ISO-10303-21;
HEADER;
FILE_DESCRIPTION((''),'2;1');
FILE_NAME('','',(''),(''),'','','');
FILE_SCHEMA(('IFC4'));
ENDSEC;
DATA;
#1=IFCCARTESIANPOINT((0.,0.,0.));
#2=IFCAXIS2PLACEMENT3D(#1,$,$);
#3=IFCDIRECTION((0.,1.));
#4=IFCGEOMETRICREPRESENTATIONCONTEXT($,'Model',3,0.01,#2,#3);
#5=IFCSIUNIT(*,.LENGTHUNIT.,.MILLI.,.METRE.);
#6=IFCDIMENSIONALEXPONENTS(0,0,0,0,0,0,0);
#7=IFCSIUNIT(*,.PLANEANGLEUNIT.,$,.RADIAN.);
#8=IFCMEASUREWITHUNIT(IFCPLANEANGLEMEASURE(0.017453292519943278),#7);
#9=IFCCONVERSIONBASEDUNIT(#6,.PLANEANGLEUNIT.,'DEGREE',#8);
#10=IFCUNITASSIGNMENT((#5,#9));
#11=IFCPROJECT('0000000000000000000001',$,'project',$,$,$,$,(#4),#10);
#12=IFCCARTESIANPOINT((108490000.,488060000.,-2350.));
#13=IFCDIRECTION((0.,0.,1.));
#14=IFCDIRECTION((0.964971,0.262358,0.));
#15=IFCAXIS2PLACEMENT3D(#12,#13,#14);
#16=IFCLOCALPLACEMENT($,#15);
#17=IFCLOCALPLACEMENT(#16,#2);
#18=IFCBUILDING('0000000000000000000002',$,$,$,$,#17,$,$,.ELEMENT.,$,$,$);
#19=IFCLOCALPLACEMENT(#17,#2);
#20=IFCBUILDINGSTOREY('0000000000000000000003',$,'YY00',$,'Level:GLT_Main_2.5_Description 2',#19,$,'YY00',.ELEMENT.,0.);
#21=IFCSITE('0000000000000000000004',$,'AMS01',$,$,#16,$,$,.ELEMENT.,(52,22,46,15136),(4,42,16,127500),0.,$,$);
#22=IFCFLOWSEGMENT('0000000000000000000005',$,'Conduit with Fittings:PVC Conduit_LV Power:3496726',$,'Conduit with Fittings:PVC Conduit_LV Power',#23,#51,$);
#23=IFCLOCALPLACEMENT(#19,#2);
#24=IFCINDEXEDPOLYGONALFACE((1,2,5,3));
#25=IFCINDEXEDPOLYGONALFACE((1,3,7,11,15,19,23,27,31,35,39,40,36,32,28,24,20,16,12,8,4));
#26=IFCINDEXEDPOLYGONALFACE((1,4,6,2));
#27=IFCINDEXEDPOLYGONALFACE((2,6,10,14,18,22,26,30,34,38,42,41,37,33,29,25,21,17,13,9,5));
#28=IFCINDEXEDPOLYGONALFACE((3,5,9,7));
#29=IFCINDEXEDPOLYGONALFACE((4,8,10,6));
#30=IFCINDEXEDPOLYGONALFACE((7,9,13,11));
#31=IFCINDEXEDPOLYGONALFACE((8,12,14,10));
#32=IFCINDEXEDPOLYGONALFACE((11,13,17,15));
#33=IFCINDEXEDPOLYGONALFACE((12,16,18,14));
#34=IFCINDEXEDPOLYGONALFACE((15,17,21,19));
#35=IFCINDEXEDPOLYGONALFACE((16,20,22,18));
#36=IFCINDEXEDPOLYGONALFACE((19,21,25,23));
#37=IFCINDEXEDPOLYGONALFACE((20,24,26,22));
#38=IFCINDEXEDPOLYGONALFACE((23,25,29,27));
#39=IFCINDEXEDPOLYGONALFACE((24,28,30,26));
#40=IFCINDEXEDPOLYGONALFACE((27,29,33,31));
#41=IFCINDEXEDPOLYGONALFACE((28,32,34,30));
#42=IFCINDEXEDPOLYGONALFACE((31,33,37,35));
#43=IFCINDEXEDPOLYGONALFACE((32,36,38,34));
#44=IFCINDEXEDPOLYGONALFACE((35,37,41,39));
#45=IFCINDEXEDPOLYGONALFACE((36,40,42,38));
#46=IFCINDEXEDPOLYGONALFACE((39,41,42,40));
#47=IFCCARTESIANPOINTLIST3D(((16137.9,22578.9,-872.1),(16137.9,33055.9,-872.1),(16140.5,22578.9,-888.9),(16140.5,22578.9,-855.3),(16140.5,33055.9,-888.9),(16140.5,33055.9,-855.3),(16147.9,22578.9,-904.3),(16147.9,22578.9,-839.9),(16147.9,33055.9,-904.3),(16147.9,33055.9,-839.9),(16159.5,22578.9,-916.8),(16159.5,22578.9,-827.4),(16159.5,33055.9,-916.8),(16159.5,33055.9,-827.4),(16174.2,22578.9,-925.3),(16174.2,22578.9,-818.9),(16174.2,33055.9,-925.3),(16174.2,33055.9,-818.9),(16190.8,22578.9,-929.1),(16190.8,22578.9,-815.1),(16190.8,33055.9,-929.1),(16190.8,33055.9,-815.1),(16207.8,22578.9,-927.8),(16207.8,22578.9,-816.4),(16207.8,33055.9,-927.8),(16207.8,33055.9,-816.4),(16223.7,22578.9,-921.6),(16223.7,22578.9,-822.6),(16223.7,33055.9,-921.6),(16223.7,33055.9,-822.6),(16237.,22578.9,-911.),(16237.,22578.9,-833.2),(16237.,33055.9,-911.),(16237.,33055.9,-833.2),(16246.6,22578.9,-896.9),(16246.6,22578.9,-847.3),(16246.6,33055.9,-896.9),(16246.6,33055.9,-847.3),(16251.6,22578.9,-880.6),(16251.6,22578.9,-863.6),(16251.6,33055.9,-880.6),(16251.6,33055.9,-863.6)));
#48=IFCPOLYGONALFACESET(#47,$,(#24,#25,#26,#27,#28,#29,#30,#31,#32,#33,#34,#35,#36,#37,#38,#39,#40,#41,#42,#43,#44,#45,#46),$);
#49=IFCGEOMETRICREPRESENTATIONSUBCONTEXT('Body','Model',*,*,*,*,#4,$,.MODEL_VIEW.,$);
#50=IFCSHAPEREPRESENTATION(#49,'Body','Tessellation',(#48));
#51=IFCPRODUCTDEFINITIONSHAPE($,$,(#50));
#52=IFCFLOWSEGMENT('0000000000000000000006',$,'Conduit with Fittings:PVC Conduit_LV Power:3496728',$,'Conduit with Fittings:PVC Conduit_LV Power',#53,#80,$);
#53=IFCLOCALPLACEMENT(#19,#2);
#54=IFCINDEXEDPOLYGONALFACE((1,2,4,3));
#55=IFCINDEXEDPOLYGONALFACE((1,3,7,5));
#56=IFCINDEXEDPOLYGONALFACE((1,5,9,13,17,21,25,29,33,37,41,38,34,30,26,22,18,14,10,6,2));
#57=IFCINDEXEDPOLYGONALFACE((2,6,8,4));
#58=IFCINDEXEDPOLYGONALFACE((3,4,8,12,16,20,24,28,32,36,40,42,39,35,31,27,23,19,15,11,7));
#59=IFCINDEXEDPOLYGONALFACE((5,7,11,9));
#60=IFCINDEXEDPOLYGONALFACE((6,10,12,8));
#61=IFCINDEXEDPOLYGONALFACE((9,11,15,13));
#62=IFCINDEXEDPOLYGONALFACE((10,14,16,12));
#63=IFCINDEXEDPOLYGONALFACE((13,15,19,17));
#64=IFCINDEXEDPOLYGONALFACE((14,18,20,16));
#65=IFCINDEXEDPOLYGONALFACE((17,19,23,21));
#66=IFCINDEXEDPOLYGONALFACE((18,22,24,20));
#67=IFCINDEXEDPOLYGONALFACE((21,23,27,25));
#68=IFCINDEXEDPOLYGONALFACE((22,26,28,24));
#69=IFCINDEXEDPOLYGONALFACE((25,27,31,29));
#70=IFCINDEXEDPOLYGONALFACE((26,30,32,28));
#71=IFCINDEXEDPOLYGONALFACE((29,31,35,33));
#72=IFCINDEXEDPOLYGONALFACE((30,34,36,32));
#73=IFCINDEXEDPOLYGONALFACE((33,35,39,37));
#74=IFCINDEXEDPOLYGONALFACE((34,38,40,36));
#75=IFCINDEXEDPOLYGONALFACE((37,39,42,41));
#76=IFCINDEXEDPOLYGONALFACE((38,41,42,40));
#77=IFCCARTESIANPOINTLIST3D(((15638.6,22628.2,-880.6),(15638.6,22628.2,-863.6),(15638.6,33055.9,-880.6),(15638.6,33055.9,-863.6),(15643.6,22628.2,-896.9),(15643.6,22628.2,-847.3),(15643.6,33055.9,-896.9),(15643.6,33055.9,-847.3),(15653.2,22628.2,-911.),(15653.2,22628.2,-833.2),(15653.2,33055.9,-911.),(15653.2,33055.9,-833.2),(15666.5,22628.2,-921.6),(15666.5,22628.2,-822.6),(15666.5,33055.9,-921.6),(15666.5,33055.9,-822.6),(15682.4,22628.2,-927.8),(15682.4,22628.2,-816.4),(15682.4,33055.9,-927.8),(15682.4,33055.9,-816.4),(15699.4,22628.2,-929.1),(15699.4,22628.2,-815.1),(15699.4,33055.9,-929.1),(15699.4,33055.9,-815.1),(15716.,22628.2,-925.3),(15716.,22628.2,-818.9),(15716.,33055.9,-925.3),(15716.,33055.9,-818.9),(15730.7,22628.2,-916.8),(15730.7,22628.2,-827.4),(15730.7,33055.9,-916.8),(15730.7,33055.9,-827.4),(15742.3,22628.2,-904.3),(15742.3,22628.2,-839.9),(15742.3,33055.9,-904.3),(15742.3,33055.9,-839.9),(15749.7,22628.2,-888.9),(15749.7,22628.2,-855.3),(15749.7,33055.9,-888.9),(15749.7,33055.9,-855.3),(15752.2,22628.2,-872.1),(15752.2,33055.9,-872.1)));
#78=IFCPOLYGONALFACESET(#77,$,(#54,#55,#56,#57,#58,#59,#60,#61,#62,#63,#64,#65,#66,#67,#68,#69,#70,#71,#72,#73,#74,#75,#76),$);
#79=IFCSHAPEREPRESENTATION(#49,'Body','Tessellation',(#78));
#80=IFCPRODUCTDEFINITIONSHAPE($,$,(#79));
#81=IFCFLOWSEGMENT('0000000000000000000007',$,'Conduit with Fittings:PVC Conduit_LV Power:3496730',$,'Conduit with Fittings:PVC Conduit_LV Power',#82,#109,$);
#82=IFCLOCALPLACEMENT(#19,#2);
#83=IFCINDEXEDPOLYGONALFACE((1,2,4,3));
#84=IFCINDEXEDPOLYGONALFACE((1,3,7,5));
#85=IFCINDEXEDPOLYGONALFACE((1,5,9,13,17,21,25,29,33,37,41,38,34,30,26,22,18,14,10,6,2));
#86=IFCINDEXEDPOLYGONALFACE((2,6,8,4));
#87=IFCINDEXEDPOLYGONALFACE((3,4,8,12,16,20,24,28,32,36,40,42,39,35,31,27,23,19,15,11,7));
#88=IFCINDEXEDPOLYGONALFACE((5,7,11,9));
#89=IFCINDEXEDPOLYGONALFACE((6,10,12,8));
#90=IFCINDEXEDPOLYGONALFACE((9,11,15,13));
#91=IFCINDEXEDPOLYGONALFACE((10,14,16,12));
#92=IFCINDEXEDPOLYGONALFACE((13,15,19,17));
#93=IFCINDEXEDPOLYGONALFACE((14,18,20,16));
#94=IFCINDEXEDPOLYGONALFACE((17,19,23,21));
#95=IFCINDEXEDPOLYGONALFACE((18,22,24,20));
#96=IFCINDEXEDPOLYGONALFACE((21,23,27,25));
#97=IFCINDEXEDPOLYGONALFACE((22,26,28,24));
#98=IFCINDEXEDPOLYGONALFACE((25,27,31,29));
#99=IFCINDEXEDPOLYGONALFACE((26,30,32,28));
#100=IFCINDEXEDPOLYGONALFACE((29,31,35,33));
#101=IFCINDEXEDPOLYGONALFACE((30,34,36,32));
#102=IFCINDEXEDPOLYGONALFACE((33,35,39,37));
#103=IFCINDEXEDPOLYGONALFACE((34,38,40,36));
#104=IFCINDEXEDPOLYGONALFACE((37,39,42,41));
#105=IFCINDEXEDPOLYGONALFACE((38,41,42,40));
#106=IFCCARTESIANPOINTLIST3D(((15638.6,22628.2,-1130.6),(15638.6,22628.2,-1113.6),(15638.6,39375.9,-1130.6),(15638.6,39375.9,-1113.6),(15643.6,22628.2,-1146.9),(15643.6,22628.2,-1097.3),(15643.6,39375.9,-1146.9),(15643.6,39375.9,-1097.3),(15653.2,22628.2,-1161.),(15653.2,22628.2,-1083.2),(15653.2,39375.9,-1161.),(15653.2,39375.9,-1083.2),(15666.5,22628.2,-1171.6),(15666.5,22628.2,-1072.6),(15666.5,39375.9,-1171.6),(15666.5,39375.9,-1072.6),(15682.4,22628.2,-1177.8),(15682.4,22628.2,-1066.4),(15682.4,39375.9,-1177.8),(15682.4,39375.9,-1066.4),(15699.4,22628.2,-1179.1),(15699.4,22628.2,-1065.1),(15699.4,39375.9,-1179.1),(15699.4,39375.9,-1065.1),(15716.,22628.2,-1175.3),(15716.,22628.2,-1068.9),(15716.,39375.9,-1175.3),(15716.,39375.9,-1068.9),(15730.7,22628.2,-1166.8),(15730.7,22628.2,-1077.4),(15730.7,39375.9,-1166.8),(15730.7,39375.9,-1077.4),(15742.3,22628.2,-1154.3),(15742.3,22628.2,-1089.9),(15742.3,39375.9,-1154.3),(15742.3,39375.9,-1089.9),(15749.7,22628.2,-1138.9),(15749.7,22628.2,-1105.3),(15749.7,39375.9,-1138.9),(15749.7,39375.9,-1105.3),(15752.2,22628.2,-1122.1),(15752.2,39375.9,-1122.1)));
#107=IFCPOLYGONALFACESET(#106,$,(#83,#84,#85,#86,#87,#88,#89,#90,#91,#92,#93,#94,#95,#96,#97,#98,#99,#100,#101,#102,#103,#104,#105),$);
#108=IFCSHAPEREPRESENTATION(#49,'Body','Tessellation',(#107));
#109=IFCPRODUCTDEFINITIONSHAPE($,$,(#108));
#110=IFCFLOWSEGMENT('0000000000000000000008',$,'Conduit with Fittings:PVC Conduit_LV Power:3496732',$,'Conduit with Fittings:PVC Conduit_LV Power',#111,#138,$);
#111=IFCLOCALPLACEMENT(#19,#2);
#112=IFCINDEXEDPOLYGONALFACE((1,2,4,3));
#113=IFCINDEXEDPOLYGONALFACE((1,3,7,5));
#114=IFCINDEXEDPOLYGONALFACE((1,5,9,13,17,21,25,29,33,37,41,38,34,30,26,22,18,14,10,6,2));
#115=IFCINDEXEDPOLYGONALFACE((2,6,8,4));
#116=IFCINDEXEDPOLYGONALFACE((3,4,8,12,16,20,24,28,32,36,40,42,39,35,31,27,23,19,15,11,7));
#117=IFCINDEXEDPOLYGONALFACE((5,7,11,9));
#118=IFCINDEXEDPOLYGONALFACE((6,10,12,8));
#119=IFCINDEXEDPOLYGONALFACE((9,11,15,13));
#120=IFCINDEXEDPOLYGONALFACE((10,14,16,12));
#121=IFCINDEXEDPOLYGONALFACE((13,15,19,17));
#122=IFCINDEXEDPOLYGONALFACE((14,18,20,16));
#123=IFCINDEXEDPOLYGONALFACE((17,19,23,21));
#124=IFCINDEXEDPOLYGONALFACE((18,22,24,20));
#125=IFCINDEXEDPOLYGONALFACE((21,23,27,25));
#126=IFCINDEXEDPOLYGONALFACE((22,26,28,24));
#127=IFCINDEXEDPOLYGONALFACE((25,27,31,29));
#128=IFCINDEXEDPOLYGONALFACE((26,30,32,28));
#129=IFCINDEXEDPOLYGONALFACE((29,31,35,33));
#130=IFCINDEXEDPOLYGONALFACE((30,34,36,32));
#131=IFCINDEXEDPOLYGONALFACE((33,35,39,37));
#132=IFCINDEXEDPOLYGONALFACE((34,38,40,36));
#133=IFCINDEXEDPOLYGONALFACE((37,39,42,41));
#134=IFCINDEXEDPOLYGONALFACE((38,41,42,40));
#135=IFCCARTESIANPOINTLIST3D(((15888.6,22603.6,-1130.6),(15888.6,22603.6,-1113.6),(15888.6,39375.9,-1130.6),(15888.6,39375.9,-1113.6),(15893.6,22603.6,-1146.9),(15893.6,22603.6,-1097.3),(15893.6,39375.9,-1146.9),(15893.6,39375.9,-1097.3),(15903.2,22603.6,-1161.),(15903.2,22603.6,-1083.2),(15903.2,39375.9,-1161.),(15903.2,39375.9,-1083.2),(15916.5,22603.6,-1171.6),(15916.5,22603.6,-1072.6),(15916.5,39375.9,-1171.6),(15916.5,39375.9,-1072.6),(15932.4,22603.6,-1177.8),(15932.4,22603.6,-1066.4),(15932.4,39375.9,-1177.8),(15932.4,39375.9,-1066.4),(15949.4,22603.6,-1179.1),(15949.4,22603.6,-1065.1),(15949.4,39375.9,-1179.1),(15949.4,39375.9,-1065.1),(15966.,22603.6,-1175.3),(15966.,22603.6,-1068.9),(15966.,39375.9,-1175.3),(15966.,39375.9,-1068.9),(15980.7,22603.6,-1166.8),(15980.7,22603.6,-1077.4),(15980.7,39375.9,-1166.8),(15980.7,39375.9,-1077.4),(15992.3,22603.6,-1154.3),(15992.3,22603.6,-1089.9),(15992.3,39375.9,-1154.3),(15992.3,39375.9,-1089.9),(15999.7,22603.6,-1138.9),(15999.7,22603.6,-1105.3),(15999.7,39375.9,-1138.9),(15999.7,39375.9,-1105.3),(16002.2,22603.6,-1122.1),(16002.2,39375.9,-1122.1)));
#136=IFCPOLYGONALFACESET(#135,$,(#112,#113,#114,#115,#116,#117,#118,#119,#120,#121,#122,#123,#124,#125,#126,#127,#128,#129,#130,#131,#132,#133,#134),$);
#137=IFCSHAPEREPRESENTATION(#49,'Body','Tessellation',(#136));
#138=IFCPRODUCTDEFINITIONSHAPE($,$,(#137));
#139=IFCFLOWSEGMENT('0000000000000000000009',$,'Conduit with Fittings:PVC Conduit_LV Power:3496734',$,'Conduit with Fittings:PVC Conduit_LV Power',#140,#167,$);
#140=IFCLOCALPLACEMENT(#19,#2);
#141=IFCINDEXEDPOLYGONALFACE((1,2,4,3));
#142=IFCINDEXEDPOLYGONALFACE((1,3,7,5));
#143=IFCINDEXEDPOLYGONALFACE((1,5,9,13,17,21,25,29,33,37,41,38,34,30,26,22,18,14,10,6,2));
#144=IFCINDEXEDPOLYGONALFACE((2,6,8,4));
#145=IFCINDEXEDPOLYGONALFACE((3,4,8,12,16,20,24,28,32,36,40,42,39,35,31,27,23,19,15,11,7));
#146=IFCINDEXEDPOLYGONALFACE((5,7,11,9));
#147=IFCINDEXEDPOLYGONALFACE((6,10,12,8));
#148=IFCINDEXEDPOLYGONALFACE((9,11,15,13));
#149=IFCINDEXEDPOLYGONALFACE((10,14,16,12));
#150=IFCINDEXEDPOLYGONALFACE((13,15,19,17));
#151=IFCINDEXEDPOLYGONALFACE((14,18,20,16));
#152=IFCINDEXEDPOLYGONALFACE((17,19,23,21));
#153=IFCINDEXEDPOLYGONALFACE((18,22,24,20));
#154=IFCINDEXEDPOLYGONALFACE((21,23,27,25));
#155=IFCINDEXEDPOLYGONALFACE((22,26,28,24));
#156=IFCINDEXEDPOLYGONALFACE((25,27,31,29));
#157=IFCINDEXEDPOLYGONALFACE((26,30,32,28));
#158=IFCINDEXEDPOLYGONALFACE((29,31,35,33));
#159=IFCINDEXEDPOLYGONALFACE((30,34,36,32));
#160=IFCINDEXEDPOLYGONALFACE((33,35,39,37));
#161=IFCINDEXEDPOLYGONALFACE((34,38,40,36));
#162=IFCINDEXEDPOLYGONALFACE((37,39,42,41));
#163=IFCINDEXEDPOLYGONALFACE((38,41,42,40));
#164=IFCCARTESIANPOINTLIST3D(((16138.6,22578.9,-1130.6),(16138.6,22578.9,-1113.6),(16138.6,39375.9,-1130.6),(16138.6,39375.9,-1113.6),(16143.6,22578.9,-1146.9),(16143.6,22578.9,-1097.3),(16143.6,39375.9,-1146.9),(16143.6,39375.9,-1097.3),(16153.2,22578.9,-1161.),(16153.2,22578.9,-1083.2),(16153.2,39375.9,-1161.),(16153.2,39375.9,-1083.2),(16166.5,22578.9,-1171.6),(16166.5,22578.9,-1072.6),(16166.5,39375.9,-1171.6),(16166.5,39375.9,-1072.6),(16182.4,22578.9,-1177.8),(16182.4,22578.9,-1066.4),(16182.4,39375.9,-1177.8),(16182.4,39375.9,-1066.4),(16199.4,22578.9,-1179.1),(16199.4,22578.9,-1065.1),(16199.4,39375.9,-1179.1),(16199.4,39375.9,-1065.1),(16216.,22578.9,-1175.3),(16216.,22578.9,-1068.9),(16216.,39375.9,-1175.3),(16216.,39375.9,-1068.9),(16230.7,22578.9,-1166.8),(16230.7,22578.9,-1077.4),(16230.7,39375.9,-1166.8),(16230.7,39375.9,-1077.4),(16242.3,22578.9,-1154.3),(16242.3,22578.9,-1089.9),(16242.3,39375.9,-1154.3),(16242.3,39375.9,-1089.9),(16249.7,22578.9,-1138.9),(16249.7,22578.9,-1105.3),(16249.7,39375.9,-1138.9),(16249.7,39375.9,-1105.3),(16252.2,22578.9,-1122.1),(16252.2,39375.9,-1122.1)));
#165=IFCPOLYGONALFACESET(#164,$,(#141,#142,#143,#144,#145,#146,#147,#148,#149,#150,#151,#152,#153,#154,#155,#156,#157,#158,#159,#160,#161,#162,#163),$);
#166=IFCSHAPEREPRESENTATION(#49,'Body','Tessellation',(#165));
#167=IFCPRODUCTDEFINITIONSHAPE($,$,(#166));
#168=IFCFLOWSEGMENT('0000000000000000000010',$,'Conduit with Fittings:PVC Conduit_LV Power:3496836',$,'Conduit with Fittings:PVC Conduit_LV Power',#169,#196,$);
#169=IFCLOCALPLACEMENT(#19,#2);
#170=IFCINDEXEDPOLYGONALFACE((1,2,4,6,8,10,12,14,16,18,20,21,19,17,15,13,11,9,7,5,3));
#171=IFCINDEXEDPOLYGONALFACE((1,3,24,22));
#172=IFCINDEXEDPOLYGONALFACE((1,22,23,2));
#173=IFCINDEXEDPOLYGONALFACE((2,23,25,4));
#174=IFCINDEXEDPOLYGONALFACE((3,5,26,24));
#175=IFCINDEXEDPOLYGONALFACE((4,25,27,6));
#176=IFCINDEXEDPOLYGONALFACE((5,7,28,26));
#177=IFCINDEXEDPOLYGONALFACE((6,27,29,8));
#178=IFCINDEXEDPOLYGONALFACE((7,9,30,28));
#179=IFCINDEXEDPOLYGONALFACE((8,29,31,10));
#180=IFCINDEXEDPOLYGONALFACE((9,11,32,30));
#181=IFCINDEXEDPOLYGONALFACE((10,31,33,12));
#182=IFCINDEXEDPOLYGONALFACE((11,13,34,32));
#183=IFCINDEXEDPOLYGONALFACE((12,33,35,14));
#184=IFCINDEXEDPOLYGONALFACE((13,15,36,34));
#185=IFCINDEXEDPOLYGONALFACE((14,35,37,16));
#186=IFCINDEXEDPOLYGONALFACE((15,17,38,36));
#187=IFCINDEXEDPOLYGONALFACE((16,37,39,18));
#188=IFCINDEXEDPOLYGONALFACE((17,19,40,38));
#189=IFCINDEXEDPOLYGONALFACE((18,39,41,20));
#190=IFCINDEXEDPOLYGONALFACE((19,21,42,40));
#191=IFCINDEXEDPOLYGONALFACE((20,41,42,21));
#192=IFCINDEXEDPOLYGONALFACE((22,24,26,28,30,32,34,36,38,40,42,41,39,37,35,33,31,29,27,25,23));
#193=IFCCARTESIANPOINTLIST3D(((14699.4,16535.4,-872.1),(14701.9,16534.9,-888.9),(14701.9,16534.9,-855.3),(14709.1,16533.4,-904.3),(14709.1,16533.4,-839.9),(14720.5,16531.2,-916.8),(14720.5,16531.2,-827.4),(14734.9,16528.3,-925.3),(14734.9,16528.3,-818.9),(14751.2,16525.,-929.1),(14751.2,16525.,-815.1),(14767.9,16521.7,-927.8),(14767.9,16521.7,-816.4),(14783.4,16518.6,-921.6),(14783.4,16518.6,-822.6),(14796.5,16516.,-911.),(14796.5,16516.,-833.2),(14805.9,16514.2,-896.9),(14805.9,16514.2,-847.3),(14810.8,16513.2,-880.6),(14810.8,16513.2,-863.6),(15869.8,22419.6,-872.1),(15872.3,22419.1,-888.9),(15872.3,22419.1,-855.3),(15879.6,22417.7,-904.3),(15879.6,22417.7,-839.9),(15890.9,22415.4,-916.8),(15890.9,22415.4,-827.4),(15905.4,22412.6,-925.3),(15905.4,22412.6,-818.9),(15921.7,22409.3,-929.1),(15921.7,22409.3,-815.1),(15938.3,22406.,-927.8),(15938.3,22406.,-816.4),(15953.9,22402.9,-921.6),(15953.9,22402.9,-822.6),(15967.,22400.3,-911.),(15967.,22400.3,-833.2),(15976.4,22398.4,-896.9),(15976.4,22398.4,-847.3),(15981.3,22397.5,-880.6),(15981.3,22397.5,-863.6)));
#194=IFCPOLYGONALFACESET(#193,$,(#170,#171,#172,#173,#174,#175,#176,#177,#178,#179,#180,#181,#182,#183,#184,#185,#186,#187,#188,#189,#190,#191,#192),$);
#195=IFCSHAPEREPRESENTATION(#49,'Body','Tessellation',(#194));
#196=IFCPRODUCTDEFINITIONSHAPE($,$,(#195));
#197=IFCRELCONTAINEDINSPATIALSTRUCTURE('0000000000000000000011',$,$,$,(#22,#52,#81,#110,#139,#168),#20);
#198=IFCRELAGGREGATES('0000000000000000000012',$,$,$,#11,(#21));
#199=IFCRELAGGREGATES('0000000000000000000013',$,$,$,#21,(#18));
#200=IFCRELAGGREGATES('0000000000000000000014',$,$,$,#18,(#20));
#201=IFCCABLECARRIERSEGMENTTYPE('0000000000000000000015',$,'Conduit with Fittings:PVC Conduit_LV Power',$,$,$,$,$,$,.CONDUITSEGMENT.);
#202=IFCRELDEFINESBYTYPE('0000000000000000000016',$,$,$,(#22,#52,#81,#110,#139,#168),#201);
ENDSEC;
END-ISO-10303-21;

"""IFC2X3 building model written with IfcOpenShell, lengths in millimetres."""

from ifc_helpers import new_model, entity, si_unit, converted_unit, direction, frame, frame_2d, origin, origin_2d_with_axis, place, context, subcontext, project, spatial, circle, extrude, type_object, element, save


model = new_model("IFC2X3")

# Units and contexts
model_context = context("Model", 3, precision=0.01, world=origin(), true_north=direction((0.0, 1.0)))
body_context = subcontext(model_context, "Body", "Model", "MODEL_VIEW")
ifc_project = project(units=[si_unit("LENGTHUNIT", "METRE", prefix="MILLI"), converted_unit("PLANEANGLEUNIT", "DEGREE", entity("IfcPlaneAngleMeasure", 0.017453292519943278), si_unit("PLANEANGLEUNIT", "RADIAN"), dimensions=[0, 0, 0, 0, 0, 0, 0])], contexts=[model_context])

# Site, building, storey
site_placement = place(None, frame((108490000.0, 488060000.0, -2350.0), z_axis=(0.0, 0.0, 1.0), x_axis=(0.964971, 0.262358, 0.0)))
site = spatial("IfcSite", under=ifc_project, at=site_placement, Name="AMS01", CompositionType="ELEMENT", RefLatitude=(52, 22, 46, 15136), RefLongitude=(4, 42, 16, 127500), RefElevation=0.0)
building_placement = place(site_placement, origin())
building = spatial("IfcBuilding", under=site, at=building_placement, CompositionType="ELEMENT")
storey_placement = place(building_placement, origin())
storey = spatial("IfcBuildingStorey", under=building, at=storey_placement, Name="YY00", ObjectType="Level:GLT_Main_2.5_Description 2", LongName="YY00", CompositionType="ELEMENT", Elevation=0.0)

# Flow segments
cable_carrier_segment_type = type_object("IfcCableCarrierSegmentType", Name="Conduit with Fittings:PVC Conduit_LV Power", PredefinedType="CONDUITSEGMENT")
flow_segment_1_placement = place(storey_placement, origin())
element("IfcFlowSegment", 1, at=flow_segment_1_placement, inside=storey, type_object=cable_carrier_segment_type, Name="Conduit with Fittings:PVC Conduit_LV Power:3496726", ObjectType="Conduit with Fittings:PVC Conduit_LV Power", context=body_context, shape_type="SweptSolid", body=[
    extrude(circle(Radius=57.2, at=frame_2d((0.0, 0.0), x_axis=(1.0, 0.0))), frame((16195.1, 22578.9, -872.1), z_axis=(0.0, 1.0, 0.0), x_axis=(-1.0, 0.0, 0.0)), (0.0, 0.0, 1.0), 10477.0),
])
flow_segment_2_placement = place(storey_placement, origin())
element("IfcFlowSegment", 2, at=flow_segment_2_placement, inside=storey, type_object=cable_carrier_segment_type, Name="Conduit with Fittings:PVC Conduit_LV Power:3496728", ObjectType="Conduit with Fittings:PVC Conduit_LV Power", context=body_context, shape_type="SweptSolid", body=[
    extrude(circle(Radius=57.2, at=origin_2d_with_axis()), frame((15695.1, 22628.2, -872.1), z_axis=(0.0, 1.0, 0.0), x_axis=(1.0, 0.0, 0.0)), (0.0, 0.0, 1.0), 10427.8),
])
flow_segment_3_placement = place(storey_placement, origin())
element("IfcFlowSegment", 3, at=flow_segment_3_placement, inside=storey, type_object=cable_carrier_segment_type, Name="Conduit with Fittings:PVC Conduit_LV Power:3496730", ObjectType="Conduit with Fittings:PVC Conduit_LV Power", context=body_context, shape_type="SweptSolid", body=[
    extrude(circle(Radius=57.2, at=frame_2d((0.0, 0.0), x_axis=(1.0, 0.0))), frame((15695.1, 22628.2, -1122.1), z_axis=(0.0, 1.0, 0.0), x_axis=(1.0, 0.0, 0.0)), (0.0, 0.0, 1.0), 16747.8),
])
flow_segment_4_placement = place(storey_placement, origin())
element("IfcFlowSegment", 4, at=flow_segment_4_placement, inside=storey, type_object=cable_carrier_segment_type, Name="Conduit with Fittings:PVC Conduit_LV Power:3496732", ObjectType="Conduit with Fittings:PVC Conduit_LV Power", context=body_context, shape_type="SweptSolid", body=[
    extrude(circle(Radius=57.2, at=origin_2d_with_axis()), frame((15945.1, 22603.6, -1122.1), z_axis=(0.0, 1.0, 0.0), x_axis=(1.0, 0.0, 0.0)), (0.0, 0.0, 1.0), 16772.4),
])
flow_segment_5_placement = place(storey_placement, origin())
element("IfcFlowSegment", 5, at=flow_segment_5_placement, inside=storey, type_object=cable_carrier_segment_type, Name="Conduit with Fittings:PVC Conduit_LV Power:3496734", ObjectType="Conduit with Fittings:PVC Conduit_LV Power", context=body_context, shape_type="SweptSolid", body=[
    extrude(circle(Radius=57.2, at=origin_2d_with_axis()), frame((16195.1, 22578.9, -1122.1), z_axis=(0.0, 1.0, 0.0), x_axis=(1.0, 0.0, 0.0)), (0.0, 0.0, 1.0), 16797.0),
])
flow_segment_6_placement = place(storey_placement, origin())
element("IfcFlowSegment", 6, at=flow_segment_6_placement, inside=storey, type_object=cable_carrier_segment_type, Name="Conduit with Fittings:PVC Conduit_LV Power:3496836", ObjectType="Conduit with Fittings:PVC Conduit_LV Power", context=body_context, shape_type="SweptSolid", body=[
    extrude(circle(Radius=57.2, at=origin_2d_with_axis()), frame((14755.4, 16524.2, -872.1), z_axis=(0.19509, 0.980785, 0.0), x_axis=(-0.980785, 0.19509, 0.0)), (0.0, 0.0, 1.0), 5999.6),
])

save(model, "model.ifc")
